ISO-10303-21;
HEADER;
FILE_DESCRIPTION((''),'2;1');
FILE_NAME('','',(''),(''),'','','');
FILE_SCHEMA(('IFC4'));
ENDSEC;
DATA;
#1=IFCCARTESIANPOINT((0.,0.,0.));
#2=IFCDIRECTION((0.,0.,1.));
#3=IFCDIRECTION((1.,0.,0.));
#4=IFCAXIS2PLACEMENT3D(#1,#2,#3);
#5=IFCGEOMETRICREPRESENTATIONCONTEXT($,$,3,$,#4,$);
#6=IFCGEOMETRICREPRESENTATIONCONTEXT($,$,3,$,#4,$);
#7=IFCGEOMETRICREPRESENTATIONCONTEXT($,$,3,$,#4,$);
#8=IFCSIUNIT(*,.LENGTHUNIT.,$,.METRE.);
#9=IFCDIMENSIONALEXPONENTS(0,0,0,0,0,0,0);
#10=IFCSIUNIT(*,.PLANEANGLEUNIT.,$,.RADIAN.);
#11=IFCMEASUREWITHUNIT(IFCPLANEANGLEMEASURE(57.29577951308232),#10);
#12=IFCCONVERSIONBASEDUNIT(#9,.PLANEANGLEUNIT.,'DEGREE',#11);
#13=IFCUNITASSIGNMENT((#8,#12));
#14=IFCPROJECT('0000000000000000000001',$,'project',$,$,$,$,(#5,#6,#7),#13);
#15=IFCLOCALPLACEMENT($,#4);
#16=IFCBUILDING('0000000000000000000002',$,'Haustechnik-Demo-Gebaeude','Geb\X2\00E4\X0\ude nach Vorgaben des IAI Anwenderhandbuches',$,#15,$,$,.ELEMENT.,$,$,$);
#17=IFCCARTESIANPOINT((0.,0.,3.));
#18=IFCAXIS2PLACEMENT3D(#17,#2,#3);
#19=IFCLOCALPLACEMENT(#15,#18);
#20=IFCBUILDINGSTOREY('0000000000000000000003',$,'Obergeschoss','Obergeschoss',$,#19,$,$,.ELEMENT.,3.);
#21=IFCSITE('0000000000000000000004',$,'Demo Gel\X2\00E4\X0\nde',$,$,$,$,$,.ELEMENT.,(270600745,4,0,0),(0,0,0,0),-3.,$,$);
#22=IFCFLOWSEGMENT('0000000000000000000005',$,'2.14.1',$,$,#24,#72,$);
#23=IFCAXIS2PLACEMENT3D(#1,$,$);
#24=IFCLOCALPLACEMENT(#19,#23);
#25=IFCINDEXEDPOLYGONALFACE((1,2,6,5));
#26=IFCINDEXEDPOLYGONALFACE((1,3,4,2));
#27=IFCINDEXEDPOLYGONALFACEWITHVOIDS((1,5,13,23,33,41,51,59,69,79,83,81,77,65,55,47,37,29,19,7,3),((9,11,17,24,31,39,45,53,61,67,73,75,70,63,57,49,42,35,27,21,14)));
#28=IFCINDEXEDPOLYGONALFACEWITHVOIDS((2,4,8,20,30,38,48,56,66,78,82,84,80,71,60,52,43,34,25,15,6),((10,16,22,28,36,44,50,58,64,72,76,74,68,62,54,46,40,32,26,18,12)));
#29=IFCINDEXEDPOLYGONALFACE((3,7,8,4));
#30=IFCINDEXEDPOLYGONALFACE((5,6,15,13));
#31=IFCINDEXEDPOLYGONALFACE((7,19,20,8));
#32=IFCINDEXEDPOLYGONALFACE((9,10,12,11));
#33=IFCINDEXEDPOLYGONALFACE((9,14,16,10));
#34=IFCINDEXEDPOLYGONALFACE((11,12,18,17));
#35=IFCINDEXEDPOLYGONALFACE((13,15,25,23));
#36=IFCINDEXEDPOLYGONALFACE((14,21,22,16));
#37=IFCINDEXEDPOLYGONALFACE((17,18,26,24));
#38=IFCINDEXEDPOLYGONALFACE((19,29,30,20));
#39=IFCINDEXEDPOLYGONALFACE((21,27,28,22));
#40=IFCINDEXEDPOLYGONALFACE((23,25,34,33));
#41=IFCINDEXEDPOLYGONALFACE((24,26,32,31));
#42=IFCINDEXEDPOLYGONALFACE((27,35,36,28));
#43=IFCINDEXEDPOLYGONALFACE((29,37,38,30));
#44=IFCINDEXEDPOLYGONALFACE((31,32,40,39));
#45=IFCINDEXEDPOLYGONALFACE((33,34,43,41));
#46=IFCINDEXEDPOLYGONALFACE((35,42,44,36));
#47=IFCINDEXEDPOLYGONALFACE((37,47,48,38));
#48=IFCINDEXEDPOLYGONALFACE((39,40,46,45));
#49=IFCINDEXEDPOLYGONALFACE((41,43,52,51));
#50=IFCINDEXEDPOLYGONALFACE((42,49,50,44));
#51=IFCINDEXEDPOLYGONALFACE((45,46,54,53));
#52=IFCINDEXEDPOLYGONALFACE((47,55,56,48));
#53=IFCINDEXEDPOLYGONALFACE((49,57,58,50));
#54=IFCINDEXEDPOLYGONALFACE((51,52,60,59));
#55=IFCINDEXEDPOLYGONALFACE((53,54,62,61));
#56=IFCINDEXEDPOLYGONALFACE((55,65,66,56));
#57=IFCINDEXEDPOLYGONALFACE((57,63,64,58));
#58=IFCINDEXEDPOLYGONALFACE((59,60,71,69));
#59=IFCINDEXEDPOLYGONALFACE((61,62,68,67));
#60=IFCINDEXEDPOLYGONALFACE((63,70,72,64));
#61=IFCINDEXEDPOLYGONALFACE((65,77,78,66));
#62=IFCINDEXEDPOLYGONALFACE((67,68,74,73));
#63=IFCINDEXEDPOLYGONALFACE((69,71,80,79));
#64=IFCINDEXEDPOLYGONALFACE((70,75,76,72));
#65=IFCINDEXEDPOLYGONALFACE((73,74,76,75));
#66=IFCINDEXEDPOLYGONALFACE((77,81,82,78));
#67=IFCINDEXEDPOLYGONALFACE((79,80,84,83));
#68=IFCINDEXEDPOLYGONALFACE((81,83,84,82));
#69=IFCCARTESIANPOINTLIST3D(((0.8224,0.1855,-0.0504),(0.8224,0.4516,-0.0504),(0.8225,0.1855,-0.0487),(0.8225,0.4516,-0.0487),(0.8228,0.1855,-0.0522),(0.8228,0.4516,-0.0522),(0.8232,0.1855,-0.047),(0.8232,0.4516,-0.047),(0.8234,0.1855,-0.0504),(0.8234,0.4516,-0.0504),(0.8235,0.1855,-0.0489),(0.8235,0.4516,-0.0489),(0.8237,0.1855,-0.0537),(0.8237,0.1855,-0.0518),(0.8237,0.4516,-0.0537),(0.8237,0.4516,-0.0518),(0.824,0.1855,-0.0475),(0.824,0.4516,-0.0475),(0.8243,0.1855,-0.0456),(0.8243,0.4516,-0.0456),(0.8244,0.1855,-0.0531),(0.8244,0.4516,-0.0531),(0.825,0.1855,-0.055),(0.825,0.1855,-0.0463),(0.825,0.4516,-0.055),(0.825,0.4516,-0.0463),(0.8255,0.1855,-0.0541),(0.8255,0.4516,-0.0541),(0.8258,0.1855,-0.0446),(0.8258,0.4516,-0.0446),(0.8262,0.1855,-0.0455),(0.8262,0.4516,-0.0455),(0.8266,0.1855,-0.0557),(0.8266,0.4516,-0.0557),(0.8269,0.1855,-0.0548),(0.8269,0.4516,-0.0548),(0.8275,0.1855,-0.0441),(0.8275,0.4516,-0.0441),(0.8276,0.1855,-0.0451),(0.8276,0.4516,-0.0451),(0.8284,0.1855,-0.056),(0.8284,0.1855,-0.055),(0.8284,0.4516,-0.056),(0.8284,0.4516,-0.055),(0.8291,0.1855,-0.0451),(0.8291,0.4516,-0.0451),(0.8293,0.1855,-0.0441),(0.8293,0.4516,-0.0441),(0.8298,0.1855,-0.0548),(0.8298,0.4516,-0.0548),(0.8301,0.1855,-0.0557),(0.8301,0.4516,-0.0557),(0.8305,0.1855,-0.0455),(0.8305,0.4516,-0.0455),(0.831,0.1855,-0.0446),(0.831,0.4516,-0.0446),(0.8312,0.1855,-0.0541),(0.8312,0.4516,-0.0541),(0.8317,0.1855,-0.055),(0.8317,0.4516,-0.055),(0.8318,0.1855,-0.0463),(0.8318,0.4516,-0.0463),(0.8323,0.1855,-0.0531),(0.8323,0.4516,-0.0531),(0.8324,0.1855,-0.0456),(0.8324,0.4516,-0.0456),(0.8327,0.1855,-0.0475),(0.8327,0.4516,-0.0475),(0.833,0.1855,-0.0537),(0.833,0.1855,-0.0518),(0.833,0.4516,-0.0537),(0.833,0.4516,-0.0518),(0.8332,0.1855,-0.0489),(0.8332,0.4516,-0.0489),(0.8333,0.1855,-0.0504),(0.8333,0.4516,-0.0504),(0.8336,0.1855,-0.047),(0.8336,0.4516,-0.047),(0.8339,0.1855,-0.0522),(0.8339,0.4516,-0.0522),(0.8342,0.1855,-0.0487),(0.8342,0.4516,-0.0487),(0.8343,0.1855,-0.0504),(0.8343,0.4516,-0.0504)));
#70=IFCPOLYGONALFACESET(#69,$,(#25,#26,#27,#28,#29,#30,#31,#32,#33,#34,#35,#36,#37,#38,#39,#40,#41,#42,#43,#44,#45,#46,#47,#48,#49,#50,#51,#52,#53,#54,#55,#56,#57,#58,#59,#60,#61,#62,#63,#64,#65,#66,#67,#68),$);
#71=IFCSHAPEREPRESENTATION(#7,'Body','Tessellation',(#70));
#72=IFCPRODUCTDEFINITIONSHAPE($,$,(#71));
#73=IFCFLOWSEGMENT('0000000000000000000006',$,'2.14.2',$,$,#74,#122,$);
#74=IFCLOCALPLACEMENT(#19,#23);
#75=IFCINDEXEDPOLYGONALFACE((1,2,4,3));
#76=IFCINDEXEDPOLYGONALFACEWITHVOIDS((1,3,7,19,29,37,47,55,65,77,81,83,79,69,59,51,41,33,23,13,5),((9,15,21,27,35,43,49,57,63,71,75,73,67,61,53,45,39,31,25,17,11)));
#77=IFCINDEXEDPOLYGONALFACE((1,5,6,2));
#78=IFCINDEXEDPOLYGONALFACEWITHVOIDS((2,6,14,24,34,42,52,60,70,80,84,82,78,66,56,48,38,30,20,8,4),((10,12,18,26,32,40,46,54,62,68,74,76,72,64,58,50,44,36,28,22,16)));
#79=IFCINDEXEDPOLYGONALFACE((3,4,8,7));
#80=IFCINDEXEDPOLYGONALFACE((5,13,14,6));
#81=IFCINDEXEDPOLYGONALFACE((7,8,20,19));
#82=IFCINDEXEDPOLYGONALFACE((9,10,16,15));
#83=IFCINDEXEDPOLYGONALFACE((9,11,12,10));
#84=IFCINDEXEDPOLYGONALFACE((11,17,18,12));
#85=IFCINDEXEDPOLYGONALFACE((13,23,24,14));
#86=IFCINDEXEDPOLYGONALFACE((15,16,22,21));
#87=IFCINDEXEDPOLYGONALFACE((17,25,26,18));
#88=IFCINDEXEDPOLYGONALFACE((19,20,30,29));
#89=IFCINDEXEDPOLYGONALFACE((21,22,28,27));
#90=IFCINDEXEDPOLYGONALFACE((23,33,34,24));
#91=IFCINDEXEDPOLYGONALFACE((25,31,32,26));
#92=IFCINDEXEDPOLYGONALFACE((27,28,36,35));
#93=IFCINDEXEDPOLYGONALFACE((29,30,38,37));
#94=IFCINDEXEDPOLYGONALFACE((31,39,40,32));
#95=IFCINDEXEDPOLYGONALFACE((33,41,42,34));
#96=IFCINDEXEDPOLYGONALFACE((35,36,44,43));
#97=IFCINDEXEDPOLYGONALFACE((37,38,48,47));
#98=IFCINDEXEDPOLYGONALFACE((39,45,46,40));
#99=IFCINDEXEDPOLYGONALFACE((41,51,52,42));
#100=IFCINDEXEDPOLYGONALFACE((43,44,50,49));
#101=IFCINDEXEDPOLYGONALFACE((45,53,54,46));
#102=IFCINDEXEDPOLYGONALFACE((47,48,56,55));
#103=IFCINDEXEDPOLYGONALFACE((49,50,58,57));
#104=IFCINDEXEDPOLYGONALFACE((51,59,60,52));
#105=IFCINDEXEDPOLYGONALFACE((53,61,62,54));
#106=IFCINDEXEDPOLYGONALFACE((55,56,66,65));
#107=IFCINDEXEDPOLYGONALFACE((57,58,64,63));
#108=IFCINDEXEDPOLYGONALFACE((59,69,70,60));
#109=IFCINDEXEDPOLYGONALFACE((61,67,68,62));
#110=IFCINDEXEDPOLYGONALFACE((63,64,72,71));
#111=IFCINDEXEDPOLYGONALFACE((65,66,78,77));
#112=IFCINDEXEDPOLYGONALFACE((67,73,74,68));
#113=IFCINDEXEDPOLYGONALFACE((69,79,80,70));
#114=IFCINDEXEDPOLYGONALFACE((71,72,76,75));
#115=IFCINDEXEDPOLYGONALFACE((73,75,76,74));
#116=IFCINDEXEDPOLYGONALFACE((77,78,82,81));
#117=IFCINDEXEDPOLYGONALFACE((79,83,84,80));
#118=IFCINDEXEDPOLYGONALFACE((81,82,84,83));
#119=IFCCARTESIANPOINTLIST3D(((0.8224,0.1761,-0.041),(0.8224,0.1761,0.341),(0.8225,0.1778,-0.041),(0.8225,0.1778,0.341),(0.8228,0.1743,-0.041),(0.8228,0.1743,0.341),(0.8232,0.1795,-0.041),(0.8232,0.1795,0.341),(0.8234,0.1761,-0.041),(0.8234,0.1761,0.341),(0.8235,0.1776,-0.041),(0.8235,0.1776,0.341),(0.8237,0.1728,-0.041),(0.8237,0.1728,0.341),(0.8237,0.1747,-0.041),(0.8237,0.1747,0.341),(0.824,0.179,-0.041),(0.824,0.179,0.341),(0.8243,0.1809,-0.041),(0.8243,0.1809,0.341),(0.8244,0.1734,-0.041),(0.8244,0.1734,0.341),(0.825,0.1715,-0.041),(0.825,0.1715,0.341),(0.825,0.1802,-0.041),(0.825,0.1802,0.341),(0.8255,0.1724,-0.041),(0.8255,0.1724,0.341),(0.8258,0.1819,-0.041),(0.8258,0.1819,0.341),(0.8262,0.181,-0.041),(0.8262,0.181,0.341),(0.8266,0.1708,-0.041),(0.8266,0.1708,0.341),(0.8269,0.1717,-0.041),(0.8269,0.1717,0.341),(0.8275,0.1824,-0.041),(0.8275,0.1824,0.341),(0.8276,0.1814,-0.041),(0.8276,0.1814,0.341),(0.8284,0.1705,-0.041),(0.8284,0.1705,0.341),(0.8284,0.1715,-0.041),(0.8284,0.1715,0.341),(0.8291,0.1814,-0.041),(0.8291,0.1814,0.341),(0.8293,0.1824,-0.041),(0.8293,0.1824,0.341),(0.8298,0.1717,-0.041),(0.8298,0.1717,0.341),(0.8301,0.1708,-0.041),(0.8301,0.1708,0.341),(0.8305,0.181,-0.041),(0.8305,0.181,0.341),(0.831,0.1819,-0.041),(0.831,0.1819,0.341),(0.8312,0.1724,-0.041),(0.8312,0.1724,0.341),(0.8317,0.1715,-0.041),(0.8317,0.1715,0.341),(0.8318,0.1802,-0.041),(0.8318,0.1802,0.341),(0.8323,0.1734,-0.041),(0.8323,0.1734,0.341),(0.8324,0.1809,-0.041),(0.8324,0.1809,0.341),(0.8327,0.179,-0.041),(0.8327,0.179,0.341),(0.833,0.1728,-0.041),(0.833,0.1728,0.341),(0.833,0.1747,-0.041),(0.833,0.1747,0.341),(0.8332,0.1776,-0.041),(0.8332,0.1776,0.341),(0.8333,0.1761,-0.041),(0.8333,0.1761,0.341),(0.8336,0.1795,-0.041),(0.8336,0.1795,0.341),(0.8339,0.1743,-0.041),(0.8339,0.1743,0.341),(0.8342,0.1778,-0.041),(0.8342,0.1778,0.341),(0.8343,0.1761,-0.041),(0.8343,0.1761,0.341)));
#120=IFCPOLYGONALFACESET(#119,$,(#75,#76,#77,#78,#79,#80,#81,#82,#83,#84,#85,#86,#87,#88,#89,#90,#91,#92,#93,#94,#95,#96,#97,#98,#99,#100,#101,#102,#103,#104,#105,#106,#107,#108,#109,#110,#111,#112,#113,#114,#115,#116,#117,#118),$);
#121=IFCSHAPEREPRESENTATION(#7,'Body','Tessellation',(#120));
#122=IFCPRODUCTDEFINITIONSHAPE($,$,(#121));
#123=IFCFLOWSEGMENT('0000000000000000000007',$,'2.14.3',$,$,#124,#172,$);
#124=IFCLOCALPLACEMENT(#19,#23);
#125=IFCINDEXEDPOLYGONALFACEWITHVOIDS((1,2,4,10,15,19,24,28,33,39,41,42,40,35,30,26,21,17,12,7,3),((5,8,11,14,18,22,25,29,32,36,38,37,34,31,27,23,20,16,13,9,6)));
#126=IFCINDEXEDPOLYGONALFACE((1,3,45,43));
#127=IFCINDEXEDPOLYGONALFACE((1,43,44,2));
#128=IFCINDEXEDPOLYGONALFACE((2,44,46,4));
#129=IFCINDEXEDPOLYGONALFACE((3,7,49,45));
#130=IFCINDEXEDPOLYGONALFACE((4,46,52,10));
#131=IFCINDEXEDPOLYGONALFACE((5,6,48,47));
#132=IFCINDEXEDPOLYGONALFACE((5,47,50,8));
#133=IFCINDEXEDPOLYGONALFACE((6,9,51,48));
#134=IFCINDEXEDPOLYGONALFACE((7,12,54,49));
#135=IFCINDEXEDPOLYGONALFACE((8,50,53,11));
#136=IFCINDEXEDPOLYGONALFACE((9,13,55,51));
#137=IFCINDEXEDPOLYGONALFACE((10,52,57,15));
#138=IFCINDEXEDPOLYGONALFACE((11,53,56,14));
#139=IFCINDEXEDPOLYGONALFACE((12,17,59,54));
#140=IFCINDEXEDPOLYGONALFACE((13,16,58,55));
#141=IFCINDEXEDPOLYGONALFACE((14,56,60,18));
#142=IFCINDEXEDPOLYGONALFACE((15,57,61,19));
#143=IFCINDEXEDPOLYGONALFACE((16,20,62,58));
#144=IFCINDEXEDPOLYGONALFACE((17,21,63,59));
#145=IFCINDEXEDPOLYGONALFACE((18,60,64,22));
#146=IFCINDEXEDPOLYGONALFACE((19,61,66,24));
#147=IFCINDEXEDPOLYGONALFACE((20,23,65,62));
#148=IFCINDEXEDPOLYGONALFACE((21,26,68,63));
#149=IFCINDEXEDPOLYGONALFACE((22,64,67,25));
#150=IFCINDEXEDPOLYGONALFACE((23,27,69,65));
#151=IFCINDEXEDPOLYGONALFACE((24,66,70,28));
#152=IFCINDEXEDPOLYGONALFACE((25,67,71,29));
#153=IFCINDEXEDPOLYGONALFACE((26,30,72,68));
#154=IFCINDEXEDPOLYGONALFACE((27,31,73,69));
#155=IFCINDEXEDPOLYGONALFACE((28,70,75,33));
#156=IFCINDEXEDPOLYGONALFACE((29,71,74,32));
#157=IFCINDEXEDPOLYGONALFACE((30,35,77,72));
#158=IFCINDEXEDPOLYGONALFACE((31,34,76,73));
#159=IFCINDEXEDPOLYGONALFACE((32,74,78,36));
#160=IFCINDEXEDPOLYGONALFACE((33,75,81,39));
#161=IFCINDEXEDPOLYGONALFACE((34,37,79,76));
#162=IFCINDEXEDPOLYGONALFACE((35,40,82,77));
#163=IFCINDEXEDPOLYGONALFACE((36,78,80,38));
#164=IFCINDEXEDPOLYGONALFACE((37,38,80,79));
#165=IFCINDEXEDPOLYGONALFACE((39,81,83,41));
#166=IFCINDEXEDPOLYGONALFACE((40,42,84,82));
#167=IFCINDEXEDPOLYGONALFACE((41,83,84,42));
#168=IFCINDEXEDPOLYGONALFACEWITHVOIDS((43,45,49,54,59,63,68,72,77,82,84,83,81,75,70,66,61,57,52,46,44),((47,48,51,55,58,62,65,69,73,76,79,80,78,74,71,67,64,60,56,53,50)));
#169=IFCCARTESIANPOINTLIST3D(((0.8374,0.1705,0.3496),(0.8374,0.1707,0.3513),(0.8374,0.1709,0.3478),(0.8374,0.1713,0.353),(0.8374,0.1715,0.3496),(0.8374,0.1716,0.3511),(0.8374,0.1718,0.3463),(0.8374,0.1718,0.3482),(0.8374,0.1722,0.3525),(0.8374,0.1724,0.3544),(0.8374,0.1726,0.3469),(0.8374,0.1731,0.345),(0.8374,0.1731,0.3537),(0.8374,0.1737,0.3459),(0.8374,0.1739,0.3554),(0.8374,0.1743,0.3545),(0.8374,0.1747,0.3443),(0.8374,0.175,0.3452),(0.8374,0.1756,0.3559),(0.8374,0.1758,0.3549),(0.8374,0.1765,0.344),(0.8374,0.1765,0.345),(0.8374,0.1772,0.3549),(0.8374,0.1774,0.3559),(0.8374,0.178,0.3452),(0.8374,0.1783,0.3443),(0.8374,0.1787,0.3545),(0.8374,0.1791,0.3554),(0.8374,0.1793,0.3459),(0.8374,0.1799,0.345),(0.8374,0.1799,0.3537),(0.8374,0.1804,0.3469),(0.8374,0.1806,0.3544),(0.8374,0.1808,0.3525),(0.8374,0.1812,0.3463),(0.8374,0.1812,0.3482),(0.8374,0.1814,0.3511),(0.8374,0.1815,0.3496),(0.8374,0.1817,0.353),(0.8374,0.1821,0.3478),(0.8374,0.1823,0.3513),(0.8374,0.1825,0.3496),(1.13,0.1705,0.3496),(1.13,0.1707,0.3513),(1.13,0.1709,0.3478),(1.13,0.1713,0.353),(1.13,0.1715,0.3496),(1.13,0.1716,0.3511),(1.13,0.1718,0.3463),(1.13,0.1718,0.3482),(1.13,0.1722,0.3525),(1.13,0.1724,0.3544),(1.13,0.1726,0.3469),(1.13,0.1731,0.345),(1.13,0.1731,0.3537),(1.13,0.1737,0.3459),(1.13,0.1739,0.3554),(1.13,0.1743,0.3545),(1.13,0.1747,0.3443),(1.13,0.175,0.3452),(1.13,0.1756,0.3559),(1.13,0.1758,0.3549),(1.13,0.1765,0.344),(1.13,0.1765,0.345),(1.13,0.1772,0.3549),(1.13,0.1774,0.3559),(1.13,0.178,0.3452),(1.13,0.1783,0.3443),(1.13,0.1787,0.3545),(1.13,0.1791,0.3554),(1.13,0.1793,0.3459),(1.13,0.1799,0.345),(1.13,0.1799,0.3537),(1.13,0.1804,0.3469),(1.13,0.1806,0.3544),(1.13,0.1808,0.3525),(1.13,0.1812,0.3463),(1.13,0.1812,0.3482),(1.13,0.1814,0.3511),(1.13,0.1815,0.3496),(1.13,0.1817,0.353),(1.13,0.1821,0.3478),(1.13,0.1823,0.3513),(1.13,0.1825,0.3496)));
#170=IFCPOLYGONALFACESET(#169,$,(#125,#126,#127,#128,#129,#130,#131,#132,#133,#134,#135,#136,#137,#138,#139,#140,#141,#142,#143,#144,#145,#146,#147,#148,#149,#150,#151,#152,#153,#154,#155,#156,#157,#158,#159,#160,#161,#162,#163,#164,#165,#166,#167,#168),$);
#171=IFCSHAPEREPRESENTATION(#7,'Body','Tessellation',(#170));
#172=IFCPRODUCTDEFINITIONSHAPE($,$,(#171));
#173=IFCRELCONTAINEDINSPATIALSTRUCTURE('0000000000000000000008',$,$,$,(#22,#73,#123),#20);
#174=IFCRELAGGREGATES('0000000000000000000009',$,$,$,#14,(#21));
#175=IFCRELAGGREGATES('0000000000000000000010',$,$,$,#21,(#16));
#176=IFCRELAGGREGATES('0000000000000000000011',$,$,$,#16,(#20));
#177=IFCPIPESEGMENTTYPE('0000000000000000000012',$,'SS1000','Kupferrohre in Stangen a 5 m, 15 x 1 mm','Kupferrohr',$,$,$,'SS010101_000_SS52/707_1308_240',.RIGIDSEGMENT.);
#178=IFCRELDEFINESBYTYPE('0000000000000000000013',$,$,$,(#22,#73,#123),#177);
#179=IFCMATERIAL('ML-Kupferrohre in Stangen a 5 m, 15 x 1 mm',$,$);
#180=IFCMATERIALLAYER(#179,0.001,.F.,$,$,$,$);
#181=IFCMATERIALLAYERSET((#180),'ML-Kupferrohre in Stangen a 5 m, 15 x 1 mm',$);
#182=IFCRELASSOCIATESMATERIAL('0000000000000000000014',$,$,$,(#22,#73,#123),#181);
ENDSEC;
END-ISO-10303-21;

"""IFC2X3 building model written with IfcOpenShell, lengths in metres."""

from ifc_helpers import new_model, entity, si_unit, converted_unit, frame, origin_with_axes, origin_2d_with_axis, place, context, project, spatial, hollow_circle, extrude, material, layer, layer_set, layer_usage, type_object, element, save


model = new_model("IFC2X3")

# Units and contexts
context_of_model_1 = context(None, 3, world=origin_with_axes())
context_of_model_2 = context(None, 3, world=origin_with_axes())
context_of_model_3 = context(None, 3, world=origin_with_axes())
ifc_project = project(units=[si_unit("LENGTHUNIT", "METRE"), converted_unit("PLANEANGLEUNIT", "DEGREE", entity("IfcPlaneAngleMeasure", 57.29577951308232), si_unit("PLANEANGLEUNIT", "RADIAN"), dimensions=[0, 0, 0, 0, 0, 0, 0])], contexts=[context_of_model_1, context_of_model_2, context_of_model_3])

# Site, building, storey
site = spatial("IfcSite", under=ifc_project, Name="Demo Gelände", CompositionType="ELEMENT", RefLatitude=(270600745, 4, 0, 0), RefLongitude=(0, 0, 0, 0), RefElevation=-3.0)
building_placement = place(None, origin_with_axes())
building = spatial("IfcBuilding", under=site, at=building_placement, Name="Haustechnik-Demo-Gebaeude", Description="Gebäude nach Vorgaben des IAI Anwenderhandbuches", CompositionType="ELEMENT")
storey_placement = place(building_placement, frame((0.0, 0.0, 3.0), z_axis=(0.0, 0.0, 1.0), x_axis=(1.0, 0.0, 0.0)))
storey = spatial("IfcBuildingStorey", under=building, at=storey_placement, Name="Obergeschoss", Description="Obergeschoss", CompositionType="ELEMENT", Elevation=3.0)

# Flow segments
ifc_material = material(Name="ML-Kupferrohre in Stangen a 5 m, 15 x 1 mm")
ifc_layer = layer(ifc_material, 0.001, ventilated=False)
ifc_layer_set = layer_set([ifc_layer], Name="ML-Kupferrohre in Stangen a 5 m, 15 x 1 mm")
ifc_layer_usage = layer_usage(ifc_layer_set, "AXIS2", "POSITIVE", 0.0)
pipe_segment_type_1 = type_object("IfcPipeSegmentType", Name="SS1000", Description="Kupferrohre in Stangen a 5 m, 15 x 1 mm", ApplicableOccurrence="Kupferrohr", ElementType="SS010101_000_SS52/707_1308_240", PredefinedType="RIGIDSEGMENT")
flow_segment_1_placement = place(storey_placement, frame((0.8284, 0.4516, -0.05), z_axis=(0.0, -1.0, 0.0), x_axis=(0.0, 0.0, -1.0)))
element("IfcFlowSegment", 1, at=flow_segment_1_placement, inside=storey, type_object=pipe_segment_type_1, material=ifc_layer_usage, Name="2.14.1", context=context_of_model_3, shape_type="SweptSolid", body=[
    extrude(hollow_circle(Radius=0.006, WallThickness=0.001, at=origin_2d_with_axis()), origin_with_axes(), (0.0, 0.0, 1.0), 0.2661),
])
flow_segment_2_placement = place(storey_placement, frame((0.8284, 0.1765, -0.041), z_axis=(0.0, 0.0, 1.0), x_axis=(0.0, -1.0, 0.0)))
element("IfcFlowSegment", 2, at=flow_segment_2_placement, inside=storey, type_object=pipe_segment_type_1, material=ifc_layer_usage, Name="2.14.2", context=context_of_model_3, shape_type="SweptSolid", body=[
    extrude(hollow_circle(Radius=0.006, WallThickness=0.001, at=origin_2d_with_axis()), origin_with_axes(), (0.0, 0.0, 1.0), 0.382),
])
flow_segment_3_placement = place(storey_placement, frame((0.8374, 0.1765, 0.35), z_axis=(1.0, 0.0, 0.0), x_axis=(0.0, 0.0, -1.0)))
element("IfcFlowSegment", 3, at=flow_segment_3_placement, inside=storey, type_object=pipe_segment_type_1, material=ifc_layer_usage, Name="2.14.3", context=context_of_model_3, shape_type="SweptSolid", body=[
    extrude(hollow_circle(Radius=0.006, WallThickness=0.001, at=origin_2d_with_axis()), origin_with_axes(), (0.0, 0.0, 1.0), 0.2926),
])

save(model, "model.ifc")
